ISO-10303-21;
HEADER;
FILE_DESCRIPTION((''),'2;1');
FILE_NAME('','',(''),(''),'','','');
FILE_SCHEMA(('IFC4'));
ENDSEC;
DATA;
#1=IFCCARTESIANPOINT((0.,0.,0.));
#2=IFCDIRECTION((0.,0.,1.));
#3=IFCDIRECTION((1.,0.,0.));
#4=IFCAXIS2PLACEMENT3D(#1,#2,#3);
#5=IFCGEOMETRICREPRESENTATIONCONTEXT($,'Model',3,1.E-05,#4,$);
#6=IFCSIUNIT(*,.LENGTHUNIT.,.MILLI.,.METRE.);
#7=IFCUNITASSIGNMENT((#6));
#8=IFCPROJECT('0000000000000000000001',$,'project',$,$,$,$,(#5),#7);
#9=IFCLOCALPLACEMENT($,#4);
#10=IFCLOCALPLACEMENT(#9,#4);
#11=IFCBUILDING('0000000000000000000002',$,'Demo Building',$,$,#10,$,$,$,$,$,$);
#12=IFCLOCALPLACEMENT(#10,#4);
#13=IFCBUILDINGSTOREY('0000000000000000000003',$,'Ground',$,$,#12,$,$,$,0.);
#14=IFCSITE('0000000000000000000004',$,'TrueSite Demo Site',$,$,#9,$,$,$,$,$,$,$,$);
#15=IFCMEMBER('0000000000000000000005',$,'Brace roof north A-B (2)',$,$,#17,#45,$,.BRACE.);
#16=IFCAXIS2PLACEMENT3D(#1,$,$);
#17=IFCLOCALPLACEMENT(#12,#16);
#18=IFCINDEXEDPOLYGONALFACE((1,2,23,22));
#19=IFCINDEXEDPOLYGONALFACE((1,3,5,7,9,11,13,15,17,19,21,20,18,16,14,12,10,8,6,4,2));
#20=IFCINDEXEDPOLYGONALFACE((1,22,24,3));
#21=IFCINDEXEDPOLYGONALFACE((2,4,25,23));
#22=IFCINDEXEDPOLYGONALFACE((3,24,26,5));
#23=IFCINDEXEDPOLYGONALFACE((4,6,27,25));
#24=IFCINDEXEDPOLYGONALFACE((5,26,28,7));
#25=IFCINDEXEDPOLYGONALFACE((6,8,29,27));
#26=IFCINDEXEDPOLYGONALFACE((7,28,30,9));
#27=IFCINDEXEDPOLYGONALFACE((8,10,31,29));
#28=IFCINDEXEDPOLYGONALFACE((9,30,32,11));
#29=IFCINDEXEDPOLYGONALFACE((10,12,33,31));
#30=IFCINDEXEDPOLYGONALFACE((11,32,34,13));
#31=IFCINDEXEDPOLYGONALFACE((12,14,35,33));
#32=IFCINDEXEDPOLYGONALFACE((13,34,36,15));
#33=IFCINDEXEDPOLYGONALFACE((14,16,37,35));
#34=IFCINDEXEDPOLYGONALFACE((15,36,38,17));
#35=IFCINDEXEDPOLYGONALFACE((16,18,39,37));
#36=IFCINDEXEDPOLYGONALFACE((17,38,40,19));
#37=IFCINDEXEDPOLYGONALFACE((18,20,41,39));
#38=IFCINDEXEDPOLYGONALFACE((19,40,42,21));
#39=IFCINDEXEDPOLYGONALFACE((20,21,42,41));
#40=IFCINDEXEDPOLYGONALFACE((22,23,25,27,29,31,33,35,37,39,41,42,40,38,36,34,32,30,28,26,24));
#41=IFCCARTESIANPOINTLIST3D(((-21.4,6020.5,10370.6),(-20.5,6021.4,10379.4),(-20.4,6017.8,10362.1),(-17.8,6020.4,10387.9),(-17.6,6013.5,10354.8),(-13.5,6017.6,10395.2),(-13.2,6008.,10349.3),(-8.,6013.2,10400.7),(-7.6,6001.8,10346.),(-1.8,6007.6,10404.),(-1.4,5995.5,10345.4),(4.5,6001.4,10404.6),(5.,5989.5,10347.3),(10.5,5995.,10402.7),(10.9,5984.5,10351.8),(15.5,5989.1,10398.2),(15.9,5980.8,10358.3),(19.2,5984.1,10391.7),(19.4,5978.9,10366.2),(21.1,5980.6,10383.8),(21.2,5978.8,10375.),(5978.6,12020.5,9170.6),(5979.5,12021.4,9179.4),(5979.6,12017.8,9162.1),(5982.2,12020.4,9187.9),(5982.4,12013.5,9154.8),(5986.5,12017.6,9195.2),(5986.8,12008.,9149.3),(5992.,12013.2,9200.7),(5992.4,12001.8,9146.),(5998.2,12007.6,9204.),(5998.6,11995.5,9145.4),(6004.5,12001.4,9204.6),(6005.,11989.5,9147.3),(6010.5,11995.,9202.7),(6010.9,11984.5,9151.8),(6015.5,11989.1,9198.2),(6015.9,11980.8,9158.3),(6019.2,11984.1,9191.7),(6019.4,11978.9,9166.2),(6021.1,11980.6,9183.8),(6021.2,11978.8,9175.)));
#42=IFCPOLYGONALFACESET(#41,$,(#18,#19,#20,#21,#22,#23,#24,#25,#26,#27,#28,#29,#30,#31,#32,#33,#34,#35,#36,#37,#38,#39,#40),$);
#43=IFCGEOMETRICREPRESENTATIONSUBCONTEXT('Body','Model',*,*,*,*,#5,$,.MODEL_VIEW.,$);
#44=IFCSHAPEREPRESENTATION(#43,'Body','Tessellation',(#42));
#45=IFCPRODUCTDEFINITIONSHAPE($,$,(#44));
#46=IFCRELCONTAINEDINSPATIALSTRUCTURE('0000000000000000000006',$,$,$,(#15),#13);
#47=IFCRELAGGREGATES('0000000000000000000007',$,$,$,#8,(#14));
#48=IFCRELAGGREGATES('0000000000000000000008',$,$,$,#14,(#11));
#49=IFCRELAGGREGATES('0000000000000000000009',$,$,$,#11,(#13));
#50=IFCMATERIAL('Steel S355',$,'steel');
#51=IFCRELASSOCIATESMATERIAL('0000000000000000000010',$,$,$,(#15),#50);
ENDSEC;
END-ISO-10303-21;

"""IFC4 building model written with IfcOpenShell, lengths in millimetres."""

from ifc_helpers import new_model, si_unit, frame, origin_with_axes, place, context, subcontext, project, spatial, circle, extrude, material, element, save


model = new_model("IFC4")

# Units and contexts
model_context = context("Model", 3, precision=1e-05, world=origin_with_axes())
body_context = subcontext(model_context, "Body", "Model", "MODEL_VIEW")
ifc_project = project(units=[si_unit("LENGTHUNIT", "METRE", prefix="MILLI")], contexts=[model_context])

# Site, building, storey
site_placement = place(None, origin_with_axes())
site = spatial("IfcSite", under=ifc_project, at=site_placement, Name="TrueSite Demo Site")
building_placement = place(site_placement, origin_with_axes())
building = spatial("IfcBuilding", under=site, at=building_placement, Name="Demo Building")
storey_placement = place(building_placement, origin_with_axes())
storey = spatial("IfcBuildingStorey", under=building, at=storey_placement, Name="Ground", Elevation=0.0)

# Shared definitions
ifc_material_1 = material(Name="Steel S355", Category="steel")

# Member
member_1_placement = place(storey_placement, frame((6000.0, 12000.0, 9175.0), z_axis=(-0.70014, -0.70014, 0.140028), x_axis=(0.707107, -0.707107, 0.0)))
element("IfcMember", 1, at=member_1_placement, inside=storey, material=ifc_material_1, Name="Brace roof north A-B (2)", PredefinedType="BRACE", context=body_context, shape_type="SweptSolid", body=[
    extrude(circle(Radius=30.0), origin_with_axes(), (0.0, 0.0, 1.0), 8569.7),
])

save(model, "model.ifc")
